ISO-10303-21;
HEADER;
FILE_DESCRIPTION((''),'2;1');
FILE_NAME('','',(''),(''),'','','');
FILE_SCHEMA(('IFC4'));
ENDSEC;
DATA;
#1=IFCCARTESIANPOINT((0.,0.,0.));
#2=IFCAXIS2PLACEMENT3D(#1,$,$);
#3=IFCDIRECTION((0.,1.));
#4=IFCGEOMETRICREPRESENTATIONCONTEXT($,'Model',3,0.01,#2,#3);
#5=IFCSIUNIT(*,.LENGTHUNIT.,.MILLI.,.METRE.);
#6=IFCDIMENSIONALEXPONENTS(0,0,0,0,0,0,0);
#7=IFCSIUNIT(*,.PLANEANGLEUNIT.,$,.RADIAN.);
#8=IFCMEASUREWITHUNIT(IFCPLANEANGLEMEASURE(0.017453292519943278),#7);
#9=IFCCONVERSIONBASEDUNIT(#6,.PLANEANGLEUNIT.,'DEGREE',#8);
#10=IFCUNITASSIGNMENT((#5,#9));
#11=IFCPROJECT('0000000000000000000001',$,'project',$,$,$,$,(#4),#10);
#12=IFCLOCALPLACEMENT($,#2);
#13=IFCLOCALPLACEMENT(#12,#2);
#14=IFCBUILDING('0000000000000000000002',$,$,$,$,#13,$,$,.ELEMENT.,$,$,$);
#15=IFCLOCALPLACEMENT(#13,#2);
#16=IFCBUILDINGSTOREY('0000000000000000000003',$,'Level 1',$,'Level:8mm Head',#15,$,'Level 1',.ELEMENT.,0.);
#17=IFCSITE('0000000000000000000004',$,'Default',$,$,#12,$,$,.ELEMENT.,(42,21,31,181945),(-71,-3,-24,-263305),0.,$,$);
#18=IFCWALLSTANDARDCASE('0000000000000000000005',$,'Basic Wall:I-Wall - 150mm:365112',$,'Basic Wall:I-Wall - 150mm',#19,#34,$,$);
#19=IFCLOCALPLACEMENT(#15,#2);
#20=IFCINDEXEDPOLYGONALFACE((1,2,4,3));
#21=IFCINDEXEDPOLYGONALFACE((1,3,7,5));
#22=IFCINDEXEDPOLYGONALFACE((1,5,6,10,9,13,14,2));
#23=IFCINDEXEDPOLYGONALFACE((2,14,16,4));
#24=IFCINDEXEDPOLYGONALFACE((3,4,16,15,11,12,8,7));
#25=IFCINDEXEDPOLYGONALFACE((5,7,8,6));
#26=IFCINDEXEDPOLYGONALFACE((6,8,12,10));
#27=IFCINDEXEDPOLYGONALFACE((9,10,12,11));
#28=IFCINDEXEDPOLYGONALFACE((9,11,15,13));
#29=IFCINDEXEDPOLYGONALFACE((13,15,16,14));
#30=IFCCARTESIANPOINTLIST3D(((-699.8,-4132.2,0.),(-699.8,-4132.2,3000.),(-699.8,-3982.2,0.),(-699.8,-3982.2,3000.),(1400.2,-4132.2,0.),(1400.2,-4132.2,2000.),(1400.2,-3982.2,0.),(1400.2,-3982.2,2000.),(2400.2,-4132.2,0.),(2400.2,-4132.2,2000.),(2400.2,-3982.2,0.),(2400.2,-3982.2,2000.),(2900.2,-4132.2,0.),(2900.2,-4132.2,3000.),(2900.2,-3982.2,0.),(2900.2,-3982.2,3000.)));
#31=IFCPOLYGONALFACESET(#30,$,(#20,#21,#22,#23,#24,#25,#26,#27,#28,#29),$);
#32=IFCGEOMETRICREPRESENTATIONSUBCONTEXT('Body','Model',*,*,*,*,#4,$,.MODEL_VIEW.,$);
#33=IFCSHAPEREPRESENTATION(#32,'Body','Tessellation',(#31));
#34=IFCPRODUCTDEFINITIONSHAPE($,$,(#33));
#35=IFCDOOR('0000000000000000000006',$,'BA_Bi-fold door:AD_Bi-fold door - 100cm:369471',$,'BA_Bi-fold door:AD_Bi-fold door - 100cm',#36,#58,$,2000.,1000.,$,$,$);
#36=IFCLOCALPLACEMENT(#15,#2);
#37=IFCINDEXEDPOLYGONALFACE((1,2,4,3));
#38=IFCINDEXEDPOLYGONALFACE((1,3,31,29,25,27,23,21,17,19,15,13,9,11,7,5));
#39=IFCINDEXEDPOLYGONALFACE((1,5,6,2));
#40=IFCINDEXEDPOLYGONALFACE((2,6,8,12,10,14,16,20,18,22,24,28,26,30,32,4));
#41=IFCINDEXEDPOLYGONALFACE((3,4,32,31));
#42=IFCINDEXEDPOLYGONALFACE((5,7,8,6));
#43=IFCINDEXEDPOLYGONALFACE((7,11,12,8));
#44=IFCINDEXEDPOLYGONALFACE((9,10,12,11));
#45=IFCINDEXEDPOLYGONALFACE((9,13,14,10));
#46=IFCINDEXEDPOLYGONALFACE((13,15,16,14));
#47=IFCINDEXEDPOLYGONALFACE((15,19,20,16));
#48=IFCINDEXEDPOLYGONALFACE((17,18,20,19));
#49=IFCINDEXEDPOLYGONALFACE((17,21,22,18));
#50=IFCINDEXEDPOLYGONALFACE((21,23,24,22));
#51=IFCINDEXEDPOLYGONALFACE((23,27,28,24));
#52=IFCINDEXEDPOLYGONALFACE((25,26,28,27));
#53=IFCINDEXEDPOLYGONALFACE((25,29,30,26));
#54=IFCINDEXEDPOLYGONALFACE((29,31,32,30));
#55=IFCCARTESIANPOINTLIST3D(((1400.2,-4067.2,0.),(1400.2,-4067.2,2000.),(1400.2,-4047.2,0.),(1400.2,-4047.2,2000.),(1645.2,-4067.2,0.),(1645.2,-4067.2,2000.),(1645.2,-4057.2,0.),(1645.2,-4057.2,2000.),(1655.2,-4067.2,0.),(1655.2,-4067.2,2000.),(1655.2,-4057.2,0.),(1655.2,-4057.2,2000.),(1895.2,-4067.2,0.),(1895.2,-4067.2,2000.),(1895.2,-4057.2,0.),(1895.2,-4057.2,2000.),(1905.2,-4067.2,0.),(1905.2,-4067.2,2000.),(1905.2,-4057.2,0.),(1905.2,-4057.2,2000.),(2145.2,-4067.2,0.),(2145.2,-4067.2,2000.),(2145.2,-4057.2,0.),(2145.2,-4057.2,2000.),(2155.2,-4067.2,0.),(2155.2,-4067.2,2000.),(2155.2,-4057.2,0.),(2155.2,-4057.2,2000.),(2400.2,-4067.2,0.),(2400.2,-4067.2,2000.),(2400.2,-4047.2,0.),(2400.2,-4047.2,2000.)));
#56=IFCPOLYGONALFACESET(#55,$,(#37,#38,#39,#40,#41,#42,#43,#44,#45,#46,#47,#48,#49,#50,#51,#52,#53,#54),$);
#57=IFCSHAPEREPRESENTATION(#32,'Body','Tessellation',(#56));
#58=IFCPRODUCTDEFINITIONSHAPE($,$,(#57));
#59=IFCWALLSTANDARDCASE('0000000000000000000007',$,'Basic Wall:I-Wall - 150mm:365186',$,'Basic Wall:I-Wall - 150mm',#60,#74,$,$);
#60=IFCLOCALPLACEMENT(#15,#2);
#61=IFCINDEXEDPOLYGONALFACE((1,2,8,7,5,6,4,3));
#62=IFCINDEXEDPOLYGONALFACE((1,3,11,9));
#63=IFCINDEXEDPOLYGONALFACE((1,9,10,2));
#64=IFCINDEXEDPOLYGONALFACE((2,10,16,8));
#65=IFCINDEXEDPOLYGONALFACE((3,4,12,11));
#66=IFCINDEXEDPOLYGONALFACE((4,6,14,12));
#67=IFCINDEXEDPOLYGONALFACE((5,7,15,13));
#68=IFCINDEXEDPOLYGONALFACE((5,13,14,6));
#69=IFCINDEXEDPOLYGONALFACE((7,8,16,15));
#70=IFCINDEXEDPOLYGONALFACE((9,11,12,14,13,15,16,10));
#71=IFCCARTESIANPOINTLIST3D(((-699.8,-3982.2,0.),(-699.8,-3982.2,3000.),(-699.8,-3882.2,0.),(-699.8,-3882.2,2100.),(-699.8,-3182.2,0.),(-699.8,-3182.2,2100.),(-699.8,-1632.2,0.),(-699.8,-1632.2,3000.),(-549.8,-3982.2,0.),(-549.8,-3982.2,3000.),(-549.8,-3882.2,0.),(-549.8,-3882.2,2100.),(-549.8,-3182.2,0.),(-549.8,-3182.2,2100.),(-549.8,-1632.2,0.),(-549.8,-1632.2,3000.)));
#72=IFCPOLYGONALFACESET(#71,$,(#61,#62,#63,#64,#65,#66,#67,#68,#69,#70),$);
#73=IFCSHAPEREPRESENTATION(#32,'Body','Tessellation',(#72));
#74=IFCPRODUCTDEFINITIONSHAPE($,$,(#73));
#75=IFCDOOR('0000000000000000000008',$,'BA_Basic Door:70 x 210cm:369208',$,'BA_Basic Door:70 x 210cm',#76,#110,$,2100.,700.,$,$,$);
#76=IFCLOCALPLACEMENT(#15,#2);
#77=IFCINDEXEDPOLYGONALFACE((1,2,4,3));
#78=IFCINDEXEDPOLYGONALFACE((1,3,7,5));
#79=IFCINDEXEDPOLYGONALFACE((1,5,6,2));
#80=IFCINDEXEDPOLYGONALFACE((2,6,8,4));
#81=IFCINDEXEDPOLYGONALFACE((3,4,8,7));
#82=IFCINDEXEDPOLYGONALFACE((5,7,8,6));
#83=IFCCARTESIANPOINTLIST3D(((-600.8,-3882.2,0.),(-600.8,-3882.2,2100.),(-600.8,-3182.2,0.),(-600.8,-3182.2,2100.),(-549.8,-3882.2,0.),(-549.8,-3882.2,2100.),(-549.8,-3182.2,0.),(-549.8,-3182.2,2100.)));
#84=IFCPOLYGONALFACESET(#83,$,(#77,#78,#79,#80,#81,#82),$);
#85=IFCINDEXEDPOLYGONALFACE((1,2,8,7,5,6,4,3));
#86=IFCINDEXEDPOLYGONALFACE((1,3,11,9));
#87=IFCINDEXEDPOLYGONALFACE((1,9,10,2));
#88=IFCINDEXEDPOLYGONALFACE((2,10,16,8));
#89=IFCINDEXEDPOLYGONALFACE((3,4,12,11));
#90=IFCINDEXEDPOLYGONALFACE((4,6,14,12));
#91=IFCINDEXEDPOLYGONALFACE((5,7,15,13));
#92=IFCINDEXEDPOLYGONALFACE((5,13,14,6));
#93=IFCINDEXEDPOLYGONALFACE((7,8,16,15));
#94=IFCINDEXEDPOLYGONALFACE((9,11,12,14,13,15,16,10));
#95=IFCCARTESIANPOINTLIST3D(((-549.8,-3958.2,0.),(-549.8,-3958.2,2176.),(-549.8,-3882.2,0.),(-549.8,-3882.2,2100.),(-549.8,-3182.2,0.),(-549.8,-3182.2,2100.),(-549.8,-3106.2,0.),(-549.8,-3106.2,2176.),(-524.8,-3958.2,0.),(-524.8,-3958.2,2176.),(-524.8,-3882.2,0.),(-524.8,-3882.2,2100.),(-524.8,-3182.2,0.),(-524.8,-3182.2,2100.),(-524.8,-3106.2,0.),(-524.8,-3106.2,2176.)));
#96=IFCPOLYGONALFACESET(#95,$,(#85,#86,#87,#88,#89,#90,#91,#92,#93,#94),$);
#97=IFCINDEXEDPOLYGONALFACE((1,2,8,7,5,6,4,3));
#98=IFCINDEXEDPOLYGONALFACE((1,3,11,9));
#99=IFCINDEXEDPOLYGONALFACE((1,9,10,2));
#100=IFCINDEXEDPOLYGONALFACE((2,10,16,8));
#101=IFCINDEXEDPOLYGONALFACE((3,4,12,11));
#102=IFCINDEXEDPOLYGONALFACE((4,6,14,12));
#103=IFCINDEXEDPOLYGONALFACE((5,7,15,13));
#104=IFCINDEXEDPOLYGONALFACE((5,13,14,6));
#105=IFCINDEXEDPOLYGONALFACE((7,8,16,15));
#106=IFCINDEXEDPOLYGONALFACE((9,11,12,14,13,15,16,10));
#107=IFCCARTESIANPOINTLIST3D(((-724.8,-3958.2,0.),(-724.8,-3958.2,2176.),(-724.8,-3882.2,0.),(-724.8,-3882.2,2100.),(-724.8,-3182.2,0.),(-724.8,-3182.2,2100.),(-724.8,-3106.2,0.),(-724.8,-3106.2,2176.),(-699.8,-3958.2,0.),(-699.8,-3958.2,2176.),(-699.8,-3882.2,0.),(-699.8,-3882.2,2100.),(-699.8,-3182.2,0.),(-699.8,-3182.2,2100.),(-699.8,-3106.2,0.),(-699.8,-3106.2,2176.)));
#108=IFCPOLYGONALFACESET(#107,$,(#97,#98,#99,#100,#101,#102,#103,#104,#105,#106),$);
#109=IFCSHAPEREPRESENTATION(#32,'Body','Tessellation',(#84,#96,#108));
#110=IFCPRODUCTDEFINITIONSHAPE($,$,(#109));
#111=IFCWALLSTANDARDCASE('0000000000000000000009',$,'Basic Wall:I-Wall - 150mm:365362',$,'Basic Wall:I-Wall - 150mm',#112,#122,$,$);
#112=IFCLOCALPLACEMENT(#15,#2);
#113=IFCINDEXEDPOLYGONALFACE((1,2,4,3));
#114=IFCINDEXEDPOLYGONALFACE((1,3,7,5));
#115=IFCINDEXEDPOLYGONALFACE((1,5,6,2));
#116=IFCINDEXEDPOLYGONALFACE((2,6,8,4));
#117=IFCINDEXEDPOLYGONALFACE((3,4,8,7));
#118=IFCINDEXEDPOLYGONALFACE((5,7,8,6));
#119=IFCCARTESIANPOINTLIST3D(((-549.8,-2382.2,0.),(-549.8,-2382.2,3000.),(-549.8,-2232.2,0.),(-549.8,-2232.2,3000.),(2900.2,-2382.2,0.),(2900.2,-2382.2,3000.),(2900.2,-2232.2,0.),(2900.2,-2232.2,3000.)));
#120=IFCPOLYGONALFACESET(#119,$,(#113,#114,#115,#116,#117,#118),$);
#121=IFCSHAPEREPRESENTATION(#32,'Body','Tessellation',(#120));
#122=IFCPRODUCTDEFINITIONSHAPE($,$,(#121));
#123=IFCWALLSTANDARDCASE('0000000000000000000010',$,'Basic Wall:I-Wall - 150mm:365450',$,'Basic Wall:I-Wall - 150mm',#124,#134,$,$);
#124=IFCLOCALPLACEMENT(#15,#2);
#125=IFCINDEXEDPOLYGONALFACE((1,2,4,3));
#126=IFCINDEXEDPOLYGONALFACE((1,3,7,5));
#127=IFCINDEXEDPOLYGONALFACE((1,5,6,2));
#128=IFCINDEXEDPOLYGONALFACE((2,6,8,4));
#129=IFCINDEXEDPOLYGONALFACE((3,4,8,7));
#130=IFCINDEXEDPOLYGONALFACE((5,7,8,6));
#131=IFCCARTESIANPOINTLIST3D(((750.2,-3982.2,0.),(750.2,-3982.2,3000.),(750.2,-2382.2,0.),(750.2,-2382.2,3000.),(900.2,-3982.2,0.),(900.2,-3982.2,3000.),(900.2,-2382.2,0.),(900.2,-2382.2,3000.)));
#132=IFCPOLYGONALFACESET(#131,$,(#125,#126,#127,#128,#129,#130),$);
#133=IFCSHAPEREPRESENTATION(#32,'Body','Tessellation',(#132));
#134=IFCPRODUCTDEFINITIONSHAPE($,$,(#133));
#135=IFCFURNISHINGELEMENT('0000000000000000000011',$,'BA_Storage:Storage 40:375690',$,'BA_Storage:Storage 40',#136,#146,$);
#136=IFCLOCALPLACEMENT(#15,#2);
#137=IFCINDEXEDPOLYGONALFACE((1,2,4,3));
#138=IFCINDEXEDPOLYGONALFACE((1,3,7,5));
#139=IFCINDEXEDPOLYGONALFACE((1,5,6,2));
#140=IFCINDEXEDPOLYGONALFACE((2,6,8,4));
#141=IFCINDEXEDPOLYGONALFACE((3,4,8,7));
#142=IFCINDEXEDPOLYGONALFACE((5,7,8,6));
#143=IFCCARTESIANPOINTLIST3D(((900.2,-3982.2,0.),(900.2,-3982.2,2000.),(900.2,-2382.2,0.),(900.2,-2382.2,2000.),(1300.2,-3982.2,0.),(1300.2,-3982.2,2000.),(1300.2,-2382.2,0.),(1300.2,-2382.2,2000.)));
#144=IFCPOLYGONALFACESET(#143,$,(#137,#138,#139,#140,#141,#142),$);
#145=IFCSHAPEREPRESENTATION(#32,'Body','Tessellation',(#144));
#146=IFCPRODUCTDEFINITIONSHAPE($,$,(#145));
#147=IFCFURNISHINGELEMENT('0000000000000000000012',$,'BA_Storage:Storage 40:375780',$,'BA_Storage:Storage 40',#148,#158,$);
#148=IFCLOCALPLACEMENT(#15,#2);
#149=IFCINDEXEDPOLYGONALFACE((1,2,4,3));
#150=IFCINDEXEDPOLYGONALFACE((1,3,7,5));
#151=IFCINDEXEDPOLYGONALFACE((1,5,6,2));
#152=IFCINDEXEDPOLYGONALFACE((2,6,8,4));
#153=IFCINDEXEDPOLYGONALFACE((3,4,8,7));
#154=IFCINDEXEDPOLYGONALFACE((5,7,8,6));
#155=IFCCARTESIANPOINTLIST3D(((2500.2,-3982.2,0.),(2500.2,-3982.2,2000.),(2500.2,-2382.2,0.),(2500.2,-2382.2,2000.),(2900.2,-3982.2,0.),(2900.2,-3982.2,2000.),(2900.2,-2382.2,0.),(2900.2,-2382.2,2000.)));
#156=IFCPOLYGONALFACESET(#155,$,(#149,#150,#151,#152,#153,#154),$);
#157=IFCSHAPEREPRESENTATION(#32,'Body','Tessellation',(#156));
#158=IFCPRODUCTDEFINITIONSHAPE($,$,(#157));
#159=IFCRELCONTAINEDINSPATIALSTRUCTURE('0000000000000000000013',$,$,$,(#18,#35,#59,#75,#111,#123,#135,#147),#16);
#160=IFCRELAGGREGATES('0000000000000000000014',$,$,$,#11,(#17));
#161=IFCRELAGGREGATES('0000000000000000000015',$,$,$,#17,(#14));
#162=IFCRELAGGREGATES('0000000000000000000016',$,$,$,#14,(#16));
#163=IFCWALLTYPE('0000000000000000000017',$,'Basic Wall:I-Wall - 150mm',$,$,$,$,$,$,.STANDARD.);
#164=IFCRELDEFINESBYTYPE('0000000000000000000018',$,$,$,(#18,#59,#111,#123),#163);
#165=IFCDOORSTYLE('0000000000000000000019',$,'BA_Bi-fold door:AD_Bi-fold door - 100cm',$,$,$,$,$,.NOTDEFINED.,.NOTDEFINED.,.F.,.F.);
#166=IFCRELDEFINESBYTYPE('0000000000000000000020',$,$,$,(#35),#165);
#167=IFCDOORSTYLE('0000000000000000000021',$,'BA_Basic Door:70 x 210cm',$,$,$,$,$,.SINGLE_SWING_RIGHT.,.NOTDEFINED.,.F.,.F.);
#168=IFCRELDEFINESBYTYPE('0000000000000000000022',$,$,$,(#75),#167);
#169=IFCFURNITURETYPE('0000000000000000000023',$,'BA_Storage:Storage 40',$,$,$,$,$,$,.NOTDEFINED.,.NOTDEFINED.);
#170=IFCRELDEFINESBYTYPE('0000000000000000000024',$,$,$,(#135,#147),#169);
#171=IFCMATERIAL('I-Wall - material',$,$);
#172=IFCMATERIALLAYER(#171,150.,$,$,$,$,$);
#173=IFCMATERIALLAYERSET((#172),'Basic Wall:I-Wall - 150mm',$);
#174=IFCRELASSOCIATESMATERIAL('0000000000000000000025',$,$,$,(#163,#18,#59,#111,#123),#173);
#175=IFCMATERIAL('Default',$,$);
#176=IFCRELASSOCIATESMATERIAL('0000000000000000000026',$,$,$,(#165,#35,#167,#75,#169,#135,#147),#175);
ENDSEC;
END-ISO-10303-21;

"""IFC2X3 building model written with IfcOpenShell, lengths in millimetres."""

from ifc_helpers import new_model, entity, si_unit, converted_unit, direction, frame, frame_2d, origin, place, context, subcontext, project, spatial, polyline, rectangle, outline, extrude, clip, bounded_halfspace, source, transform, mapped, material, layer, layer_set, layer_usage, type_object, type_shapes, element, fill, save


model = new_model("IFC2X3")

# Units and contexts
model_context = context("Model", 3, precision=0.01, world=origin(), true_north=direction((0.0, 1.0)))
body_context = subcontext(model_context, "Body", "Model", "MODEL_VIEW")
ifc_project = project(units=[si_unit("LENGTHUNIT", "METRE", prefix="MILLI"), converted_unit("PLANEANGLEUNIT", "DEGREE", entity("IfcPlaneAngleMeasure", 0.017453292519943278), si_unit("PLANEANGLEUNIT", "RADIAN"), dimensions=[0, 0, 0, 0, 0, 0, 0])], contexts=[model_context])

# Site, building, storey
site_placement = place(None, origin())
site = spatial("IfcSite", under=ifc_project, at=site_placement, Name="Default", CompositionType="ELEMENT", RefLatitude=(42, 21, 31, 181945), RefLongitude=(-71, -3, -24, -263305), RefElevation=0.0)
building_placement = place(site_placement, origin())
building = spatial("IfcBuilding", under=site, at=building_placement, CompositionType="ELEMENT")
storey_placement = place(building_placement, origin())
storey = spatial("IfcBuildingStorey", under=building, at=storey_placement, Name="Level 1", ObjectType="Level:8mm Head", LongName="Level 1", CompositionType="ELEMENT", Elevation=0.0)

# Shared definitions
ifc_material_1 = material(Name="Default")

# Walls, openings, doors
ifc_material_2 = material(Name="I-Wall - material")
ifc_layer_1 = layer(ifc_material_2, 150.0)
ifc_layer_set_1 = layer_set([ifc_layer_1], Name="Basic Wall:I-Wall - 150mm")
ifc_layer_usage_1 = layer_usage(ifc_layer_set_1, "AXIS2", "NEGATIVE", 75.0)
wall_type_1 = type_object("IfcWallType", Name="Basic Wall:I-Wall - 150mm", PredefinedType="STANDARD", material=ifc_layer_set_1)
wall_1_placement = place(storey_placement, frame((2900.2, -4057.2, 0.0), z_axis=(0.0, 0.0, 1.0), x_axis=(-1.0, 0.0, 0.0)))
wall_1 = element("IfcWallStandardCase", 1, at=wall_1_placement, inside=storey, type_object=wall_type_1, material=ifc_layer_usage_1, Name="Basic Wall:I-Wall - 150mm:365112", ObjectType="Basic Wall:I-Wall - 150mm", context=body_context, shape_type="Clipping", body=[
    clip(extrude(rectangle(XDim=3600.0, YDim=150.0, at=frame_2d((1800.0, 0.0), x_axis=(-1.0, 0.0))), origin(), (0.0, 0.0, 1.0), 3000.0), bounded_halfspace(frame((0.0, -75.0, 3000.0), z_axis=(0.0, 0.0, -1.0), x_axis=(0.0, 1.0, 0.0)), True, frame((0.0, -75.0, 3000.0)), polyline([(0.0, 0.0), (2000.0, 0.0), (2150.0, 0.0), (3450.0, 0.0), (3600.0, 0.0), (3600.0, 150.0), (0.0, 150.0), (0.0, 0.0)]))),
])
opening_1_placement = place(wall_1_placement, frame((500.0, -75.0, 0.0)))
opening_1 = element("IfcOpeningElement", 2, at=opening_1_placement, cuts=wall_1, ObjectType="Opening", context=body_context, shape_type="SweptSolid", body=[
    extrude(rectangle(XDim=2000.0, YDim=1000.0, at=frame_2d((1000.0, 500.0), x_axis=(1.0, 0.0))), frame((0.0, 0.0, 0.0), z_axis=(0.0, 1.0, 0.0), x_axis=(0.0, 0.0, 1.0)), (0.0, 0.0, 1.0), 150.0),
])
door_style_1 = type_object("IfcDoorStyle", Name="BA_Bi-fold door:AD_Bi-fold door - 100cm", ConstructionType="NOTDEFINED", OperationType="NOTDEFINED", ParameterTakesPrecedence=False, Sizeable=False, material=ifc_material_1)
shared_shape_1 = source(origin(), body_context, "Body", "SweptSolid", [
    extrude(outline(polyline([(-6.2, -255.0), (-6.2, -500.0), (13.8, -500.0), (13.8, 500.0), (-6.2, 500.0), (-6.2, 255.0), (3.8, 255.0), (3.8, 245.0), (-6.2, 245.0), (-6.2, 5.0), (3.8, 5.0), (3.8, -5.0), (-6.2, -5.0), (-6.2, -245.0), (3.8, -245.0), (3.8, -255.0), (-6.2, -255.0)])), frame((500.0, 78.7, 0.0), z_axis=(0.0, 0.0, -1.0), x_axis=(0.0, -1.0, 0.0)), (0.0, 0.0, -1.0), 2000.0),
])
type_shapes(door_style_1, [shared_shape_1])
door_1_placement = place(opening_1_placement, origin())
door_1 = element("IfcDoor", 3, at=door_1_placement, inside=storey, type_object=door_style_1, material=ifc_material_1, Name="BA_Bi-fold door:AD_Bi-fold door - 100cm:369471", ObjectType="BA_Bi-fold door:AD_Bi-fold door - 100cm", OverallHeight=2000.0, OverallWidth=1000.0, context=body_context, shape_type="MappedRepresentation", body=[
    mapped(shared_shape_1, transform((0.0, 0.0, 0.0), scale=1.0)),
])
fill(opening_1, door_1)
ifc_layer_usage_2 = layer_usage(ifc_layer_set_1, "AXIS2", "NEGATIVE", 75.0)
wall_2_placement = place(storey_placement, frame((-624.8, -3982.2, 0.0), z_axis=(0.0, 0.0, 1.0), x_axis=(0.0, 1.0, 0.0)))
wall_2 = element("IfcWallStandardCase", 4, at=wall_2_placement, inside=storey, type_object=wall_type_1, material=ifc_layer_usage_2, Name="Basic Wall:I-Wall - 150mm:365186", ObjectType="Basic Wall:I-Wall - 150mm", context=body_context, shape_type="Clipping", body=[
    clip(extrude(rectangle(XDim=2350.0, YDim=150.0, at=frame_2d((1175.0, 0.0), x_axis=(-1.0, 0.0))), origin(), (0.0, 0.0, 1.0), 3000.0), bounded_halfspace(frame((0.0, -75.0, 3000.0), z_axis=(0.0, 0.0, -1.0), x_axis=(-1.0, 0.0, 0.0)), True, frame((0.0, -75.0, 3000.0)), polyline([(0.0, 0.0), (1600.0, 0.0), (1750.0, 0.0), (2350.0, 0.0), (2350.0, 150.0), (0.0, 150.0), (0.0, 0.0)]))),
])
opening_2_placement = place(wall_2_placement, frame((800.0, 75.0, 0.0)))
opening_2 = element("IfcOpeningElement", 5, at=opening_2_placement, cuts=wall_2, ObjectType="Opening", context=body_context, shape_type="SweptSolid", body=[
    extrude(rectangle(XDim=700.0, YDim=2100.0, at=frame_2d((1050.0, 350.0), x_axis=(0.0, 1.0))), frame((0.0, 0.0, 0.0), z_axis=(0.0, -1.0, 0.0), x_axis=(0.0, 0.0, 1.0)), (0.0, 0.0, 1.0), 150.0),
])
door_style_2 = type_object("IfcDoorStyle", Name="BA_Basic Door:70 x 210cm", ConstructionType="NOTDEFINED", OperationType="SINGLE_SWING_RIGHT", ParameterTakesPrecedence=False, Sizeable=False, material=ifc_material_1)
shared_shape_2 = source(origin(), body_context, "Body", "SweptSolid", [
    extrude(rectangle(XDim=51.0, YDim=700.0, at=frame_2d((0.0, 0.0), x_axis=(1.0, 0.0))), frame((350.0, 124.5, 0.0), z_axis=(0.0, 0.0, 1.0), x_axis=(0.0, 1.0, 0.0)), (0.0, 0.0, 1.0), 2100.0),
    extrude(outline(polyline([(-426.0, -1107.0), (426.0, -1107.0), (426.0, 1069.0), (350.0, 1069.0), (350.0, -1031.0), (-350.0, -1031.0), (-350.0, 1069.0), (-426.0, 1069.0), (-426.0, -1107.0)])), frame((350.0, 150.0, 1069.0), z_axis=(0.0, 1.0, 0.0), x_axis=(1.0, 0.0, 0.0)), (0.0, 0.0, 1.0), 25.0),
    extrude(outline(polyline([(-1107.0, -426.0), (1069.0, -426.0), (1069.0, -350.0), (-1031.0, -350.0), (-1031.0, 350.0), (1069.0, 350.0), (1069.0, 426.0), (-1107.0, 426.0), (-1107.0, -426.0)])), frame((350.0, -25.0, 1069.0), z_axis=(0.0, 1.0, 0.0), x_axis=(0.0, 0.0, -1.0)), (0.0, 0.0, 1.0), 25.0),
])
type_shapes(door_style_2, [shared_shape_2])
door_2_placement = place(opening_2_placement, frame((0.0, 0.0, 0.0), z_axis=(0.0, 0.0, 1.0), x_axis=(-1.0, 0.0, 0.0)))
door_2 = element("IfcDoor", 6, at=door_2_placement, inside=storey, type_object=door_style_2, material=ifc_material_1, Name="BA_Basic Door:70 x 210cm:369208", ObjectType="BA_Basic Door:70 x 210cm", OverallHeight=2100.0, OverallWidth=700.0, context=body_context, shape_type="MappedRepresentation", body=[
    mapped(shared_shape_2, transform((0.0, 0.0, 0.0), scale=1.0)),
])
fill(opening_2, door_2)

# Walls
ifc_layer_usage_3 = layer_usage(ifc_layer_set_1, "AXIS2", "NEGATIVE", 75.0)
wall_3_placement = place(storey_placement, frame((-549.8, -2307.2, 0.0)))
element("IfcWallStandardCase", 7, at=wall_3_placement, inside=storey, type_object=wall_type_1, material=ifc_layer_usage_3, Name="Basic Wall:I-Wall - 150mm:365362", ObjectType="Basic Wall:I-Wall - 150mm", context=body_context, shape_type="Clipping", body=[
    clip(extrude(rectangle(XDim=3450.0, YDim=150.0, at=frame_2d((1725.0, 0.0), x_axis=(-1.0, 0.0))), origin(), (0.0, 0.0, 1.0), 3000.0), bounded_halfspace(frame((0.0, -75.0, 3000.0), z_axis=(0.0, 0.0, -1.0), x_axis=(0.0, -1.0, 0.0)), True, frame((0.0, -75.0, 3000.0)), polyline([(0.0, 0.0), (1300.0, 0.0), (1450.0, 0.0), (3450.0, 0.0), (3450.0, 150.0), (0.0, 150.0), (0.0, 0.0)]))),
])
ifc_layer_usage_4 = layer_usage(ifc_layer_set_1, "AXIS2", "NEGATIVE", 75.0)
wall_4_placement = place(storey_placement, frame((825.2, -2382.2, 0.0), z_axis=(0.0, 0.0, 1.0), x_axis=(0.0, -1.0, 0.0)))
element("IfcWallStandardCase", 8, at=wall_4_placement, inside=storey, type_object=wall_type_1, material=ifc_layer_usage_4, Name="Basic Wall:I-Wall - 150mm:365450", ObjectType="Basic Wall:I-Wall - 150mm", context=body_context, shape_type="Clipping", body=[
    clip(extrude(rectangle(XDim=1600.0, YDim=150.0, at=frame_2d((800.0, 0.0), x_axis=(-1.0, 0.0))), origin(), (0.0, 0.0, 1.0), 3000.0), bounded_halfspace(frame((0.0, -75.0, 3000.0), z_axis=(0.0, 0.0, -1.0), x_axis=(1.0, 0.0, 0.0)), True, frame((0.0, -75.0, 3000.0)), polyline([(0.0, 0.0), (1600.0, 0.0), (1600.0, 150.0), (0.0, 150.0), (0.0, 0.0)]))),
])

# Furnishing elements
furniture_type_1 = type_object("IfcFurnitureType", Name="BA_Storage:Storage 40", AssemblyPlace="NOTDEFINED", material=ifc_material_1)
shared_shape_3 = source(origin(), body_context, "Body", "SweptSolid", [
    extrude(rectangle(XDim=400.0, YDim=1600.0, at=frame_2d((0.0, 0.0), x_axis=(1.0, 0.0))), frame((800.0, 200.0, 0.0), z_axis=(0.0, 0.0, 1.0), x_axis=(0.0, 1.0, 0.0)), (0.0, 0.0, 1.0), 2000.0),
])
type_shapes(furniture_type_1, [shared_shape_3])
for number, where, z_axis, x_axis, name in (
    (9, (900.2, -2382.2, 0.0), (0.0, 0.0, 1.0), (0.0, -1.0, 0.0), "BA_Storage:Storage 40:375690"),
    (10, (2900.2, -3982.2, 0.0), (0.0, 0.0, 1.0), (0.0, 1.0, 0.0), "BA_Storage:Storage 40:375780"),
):
    element("IfcFurnishingElement", number, at=place(storey_placement, frame(where, z_axis=z_axis, x_axis=x_axis)), inside=storey, type_object=furniture_type_1, material=ifc_material_1, Name=name, ObjectType="BA_Storage:Storage 40", context=body_context, shape_type="MappedRepresentation", body=[
        mapped(shared_shape_3, transform((0.0, 0.0, 0.0), scale=1.0)),
    ])

save(model, "model.ifc")
